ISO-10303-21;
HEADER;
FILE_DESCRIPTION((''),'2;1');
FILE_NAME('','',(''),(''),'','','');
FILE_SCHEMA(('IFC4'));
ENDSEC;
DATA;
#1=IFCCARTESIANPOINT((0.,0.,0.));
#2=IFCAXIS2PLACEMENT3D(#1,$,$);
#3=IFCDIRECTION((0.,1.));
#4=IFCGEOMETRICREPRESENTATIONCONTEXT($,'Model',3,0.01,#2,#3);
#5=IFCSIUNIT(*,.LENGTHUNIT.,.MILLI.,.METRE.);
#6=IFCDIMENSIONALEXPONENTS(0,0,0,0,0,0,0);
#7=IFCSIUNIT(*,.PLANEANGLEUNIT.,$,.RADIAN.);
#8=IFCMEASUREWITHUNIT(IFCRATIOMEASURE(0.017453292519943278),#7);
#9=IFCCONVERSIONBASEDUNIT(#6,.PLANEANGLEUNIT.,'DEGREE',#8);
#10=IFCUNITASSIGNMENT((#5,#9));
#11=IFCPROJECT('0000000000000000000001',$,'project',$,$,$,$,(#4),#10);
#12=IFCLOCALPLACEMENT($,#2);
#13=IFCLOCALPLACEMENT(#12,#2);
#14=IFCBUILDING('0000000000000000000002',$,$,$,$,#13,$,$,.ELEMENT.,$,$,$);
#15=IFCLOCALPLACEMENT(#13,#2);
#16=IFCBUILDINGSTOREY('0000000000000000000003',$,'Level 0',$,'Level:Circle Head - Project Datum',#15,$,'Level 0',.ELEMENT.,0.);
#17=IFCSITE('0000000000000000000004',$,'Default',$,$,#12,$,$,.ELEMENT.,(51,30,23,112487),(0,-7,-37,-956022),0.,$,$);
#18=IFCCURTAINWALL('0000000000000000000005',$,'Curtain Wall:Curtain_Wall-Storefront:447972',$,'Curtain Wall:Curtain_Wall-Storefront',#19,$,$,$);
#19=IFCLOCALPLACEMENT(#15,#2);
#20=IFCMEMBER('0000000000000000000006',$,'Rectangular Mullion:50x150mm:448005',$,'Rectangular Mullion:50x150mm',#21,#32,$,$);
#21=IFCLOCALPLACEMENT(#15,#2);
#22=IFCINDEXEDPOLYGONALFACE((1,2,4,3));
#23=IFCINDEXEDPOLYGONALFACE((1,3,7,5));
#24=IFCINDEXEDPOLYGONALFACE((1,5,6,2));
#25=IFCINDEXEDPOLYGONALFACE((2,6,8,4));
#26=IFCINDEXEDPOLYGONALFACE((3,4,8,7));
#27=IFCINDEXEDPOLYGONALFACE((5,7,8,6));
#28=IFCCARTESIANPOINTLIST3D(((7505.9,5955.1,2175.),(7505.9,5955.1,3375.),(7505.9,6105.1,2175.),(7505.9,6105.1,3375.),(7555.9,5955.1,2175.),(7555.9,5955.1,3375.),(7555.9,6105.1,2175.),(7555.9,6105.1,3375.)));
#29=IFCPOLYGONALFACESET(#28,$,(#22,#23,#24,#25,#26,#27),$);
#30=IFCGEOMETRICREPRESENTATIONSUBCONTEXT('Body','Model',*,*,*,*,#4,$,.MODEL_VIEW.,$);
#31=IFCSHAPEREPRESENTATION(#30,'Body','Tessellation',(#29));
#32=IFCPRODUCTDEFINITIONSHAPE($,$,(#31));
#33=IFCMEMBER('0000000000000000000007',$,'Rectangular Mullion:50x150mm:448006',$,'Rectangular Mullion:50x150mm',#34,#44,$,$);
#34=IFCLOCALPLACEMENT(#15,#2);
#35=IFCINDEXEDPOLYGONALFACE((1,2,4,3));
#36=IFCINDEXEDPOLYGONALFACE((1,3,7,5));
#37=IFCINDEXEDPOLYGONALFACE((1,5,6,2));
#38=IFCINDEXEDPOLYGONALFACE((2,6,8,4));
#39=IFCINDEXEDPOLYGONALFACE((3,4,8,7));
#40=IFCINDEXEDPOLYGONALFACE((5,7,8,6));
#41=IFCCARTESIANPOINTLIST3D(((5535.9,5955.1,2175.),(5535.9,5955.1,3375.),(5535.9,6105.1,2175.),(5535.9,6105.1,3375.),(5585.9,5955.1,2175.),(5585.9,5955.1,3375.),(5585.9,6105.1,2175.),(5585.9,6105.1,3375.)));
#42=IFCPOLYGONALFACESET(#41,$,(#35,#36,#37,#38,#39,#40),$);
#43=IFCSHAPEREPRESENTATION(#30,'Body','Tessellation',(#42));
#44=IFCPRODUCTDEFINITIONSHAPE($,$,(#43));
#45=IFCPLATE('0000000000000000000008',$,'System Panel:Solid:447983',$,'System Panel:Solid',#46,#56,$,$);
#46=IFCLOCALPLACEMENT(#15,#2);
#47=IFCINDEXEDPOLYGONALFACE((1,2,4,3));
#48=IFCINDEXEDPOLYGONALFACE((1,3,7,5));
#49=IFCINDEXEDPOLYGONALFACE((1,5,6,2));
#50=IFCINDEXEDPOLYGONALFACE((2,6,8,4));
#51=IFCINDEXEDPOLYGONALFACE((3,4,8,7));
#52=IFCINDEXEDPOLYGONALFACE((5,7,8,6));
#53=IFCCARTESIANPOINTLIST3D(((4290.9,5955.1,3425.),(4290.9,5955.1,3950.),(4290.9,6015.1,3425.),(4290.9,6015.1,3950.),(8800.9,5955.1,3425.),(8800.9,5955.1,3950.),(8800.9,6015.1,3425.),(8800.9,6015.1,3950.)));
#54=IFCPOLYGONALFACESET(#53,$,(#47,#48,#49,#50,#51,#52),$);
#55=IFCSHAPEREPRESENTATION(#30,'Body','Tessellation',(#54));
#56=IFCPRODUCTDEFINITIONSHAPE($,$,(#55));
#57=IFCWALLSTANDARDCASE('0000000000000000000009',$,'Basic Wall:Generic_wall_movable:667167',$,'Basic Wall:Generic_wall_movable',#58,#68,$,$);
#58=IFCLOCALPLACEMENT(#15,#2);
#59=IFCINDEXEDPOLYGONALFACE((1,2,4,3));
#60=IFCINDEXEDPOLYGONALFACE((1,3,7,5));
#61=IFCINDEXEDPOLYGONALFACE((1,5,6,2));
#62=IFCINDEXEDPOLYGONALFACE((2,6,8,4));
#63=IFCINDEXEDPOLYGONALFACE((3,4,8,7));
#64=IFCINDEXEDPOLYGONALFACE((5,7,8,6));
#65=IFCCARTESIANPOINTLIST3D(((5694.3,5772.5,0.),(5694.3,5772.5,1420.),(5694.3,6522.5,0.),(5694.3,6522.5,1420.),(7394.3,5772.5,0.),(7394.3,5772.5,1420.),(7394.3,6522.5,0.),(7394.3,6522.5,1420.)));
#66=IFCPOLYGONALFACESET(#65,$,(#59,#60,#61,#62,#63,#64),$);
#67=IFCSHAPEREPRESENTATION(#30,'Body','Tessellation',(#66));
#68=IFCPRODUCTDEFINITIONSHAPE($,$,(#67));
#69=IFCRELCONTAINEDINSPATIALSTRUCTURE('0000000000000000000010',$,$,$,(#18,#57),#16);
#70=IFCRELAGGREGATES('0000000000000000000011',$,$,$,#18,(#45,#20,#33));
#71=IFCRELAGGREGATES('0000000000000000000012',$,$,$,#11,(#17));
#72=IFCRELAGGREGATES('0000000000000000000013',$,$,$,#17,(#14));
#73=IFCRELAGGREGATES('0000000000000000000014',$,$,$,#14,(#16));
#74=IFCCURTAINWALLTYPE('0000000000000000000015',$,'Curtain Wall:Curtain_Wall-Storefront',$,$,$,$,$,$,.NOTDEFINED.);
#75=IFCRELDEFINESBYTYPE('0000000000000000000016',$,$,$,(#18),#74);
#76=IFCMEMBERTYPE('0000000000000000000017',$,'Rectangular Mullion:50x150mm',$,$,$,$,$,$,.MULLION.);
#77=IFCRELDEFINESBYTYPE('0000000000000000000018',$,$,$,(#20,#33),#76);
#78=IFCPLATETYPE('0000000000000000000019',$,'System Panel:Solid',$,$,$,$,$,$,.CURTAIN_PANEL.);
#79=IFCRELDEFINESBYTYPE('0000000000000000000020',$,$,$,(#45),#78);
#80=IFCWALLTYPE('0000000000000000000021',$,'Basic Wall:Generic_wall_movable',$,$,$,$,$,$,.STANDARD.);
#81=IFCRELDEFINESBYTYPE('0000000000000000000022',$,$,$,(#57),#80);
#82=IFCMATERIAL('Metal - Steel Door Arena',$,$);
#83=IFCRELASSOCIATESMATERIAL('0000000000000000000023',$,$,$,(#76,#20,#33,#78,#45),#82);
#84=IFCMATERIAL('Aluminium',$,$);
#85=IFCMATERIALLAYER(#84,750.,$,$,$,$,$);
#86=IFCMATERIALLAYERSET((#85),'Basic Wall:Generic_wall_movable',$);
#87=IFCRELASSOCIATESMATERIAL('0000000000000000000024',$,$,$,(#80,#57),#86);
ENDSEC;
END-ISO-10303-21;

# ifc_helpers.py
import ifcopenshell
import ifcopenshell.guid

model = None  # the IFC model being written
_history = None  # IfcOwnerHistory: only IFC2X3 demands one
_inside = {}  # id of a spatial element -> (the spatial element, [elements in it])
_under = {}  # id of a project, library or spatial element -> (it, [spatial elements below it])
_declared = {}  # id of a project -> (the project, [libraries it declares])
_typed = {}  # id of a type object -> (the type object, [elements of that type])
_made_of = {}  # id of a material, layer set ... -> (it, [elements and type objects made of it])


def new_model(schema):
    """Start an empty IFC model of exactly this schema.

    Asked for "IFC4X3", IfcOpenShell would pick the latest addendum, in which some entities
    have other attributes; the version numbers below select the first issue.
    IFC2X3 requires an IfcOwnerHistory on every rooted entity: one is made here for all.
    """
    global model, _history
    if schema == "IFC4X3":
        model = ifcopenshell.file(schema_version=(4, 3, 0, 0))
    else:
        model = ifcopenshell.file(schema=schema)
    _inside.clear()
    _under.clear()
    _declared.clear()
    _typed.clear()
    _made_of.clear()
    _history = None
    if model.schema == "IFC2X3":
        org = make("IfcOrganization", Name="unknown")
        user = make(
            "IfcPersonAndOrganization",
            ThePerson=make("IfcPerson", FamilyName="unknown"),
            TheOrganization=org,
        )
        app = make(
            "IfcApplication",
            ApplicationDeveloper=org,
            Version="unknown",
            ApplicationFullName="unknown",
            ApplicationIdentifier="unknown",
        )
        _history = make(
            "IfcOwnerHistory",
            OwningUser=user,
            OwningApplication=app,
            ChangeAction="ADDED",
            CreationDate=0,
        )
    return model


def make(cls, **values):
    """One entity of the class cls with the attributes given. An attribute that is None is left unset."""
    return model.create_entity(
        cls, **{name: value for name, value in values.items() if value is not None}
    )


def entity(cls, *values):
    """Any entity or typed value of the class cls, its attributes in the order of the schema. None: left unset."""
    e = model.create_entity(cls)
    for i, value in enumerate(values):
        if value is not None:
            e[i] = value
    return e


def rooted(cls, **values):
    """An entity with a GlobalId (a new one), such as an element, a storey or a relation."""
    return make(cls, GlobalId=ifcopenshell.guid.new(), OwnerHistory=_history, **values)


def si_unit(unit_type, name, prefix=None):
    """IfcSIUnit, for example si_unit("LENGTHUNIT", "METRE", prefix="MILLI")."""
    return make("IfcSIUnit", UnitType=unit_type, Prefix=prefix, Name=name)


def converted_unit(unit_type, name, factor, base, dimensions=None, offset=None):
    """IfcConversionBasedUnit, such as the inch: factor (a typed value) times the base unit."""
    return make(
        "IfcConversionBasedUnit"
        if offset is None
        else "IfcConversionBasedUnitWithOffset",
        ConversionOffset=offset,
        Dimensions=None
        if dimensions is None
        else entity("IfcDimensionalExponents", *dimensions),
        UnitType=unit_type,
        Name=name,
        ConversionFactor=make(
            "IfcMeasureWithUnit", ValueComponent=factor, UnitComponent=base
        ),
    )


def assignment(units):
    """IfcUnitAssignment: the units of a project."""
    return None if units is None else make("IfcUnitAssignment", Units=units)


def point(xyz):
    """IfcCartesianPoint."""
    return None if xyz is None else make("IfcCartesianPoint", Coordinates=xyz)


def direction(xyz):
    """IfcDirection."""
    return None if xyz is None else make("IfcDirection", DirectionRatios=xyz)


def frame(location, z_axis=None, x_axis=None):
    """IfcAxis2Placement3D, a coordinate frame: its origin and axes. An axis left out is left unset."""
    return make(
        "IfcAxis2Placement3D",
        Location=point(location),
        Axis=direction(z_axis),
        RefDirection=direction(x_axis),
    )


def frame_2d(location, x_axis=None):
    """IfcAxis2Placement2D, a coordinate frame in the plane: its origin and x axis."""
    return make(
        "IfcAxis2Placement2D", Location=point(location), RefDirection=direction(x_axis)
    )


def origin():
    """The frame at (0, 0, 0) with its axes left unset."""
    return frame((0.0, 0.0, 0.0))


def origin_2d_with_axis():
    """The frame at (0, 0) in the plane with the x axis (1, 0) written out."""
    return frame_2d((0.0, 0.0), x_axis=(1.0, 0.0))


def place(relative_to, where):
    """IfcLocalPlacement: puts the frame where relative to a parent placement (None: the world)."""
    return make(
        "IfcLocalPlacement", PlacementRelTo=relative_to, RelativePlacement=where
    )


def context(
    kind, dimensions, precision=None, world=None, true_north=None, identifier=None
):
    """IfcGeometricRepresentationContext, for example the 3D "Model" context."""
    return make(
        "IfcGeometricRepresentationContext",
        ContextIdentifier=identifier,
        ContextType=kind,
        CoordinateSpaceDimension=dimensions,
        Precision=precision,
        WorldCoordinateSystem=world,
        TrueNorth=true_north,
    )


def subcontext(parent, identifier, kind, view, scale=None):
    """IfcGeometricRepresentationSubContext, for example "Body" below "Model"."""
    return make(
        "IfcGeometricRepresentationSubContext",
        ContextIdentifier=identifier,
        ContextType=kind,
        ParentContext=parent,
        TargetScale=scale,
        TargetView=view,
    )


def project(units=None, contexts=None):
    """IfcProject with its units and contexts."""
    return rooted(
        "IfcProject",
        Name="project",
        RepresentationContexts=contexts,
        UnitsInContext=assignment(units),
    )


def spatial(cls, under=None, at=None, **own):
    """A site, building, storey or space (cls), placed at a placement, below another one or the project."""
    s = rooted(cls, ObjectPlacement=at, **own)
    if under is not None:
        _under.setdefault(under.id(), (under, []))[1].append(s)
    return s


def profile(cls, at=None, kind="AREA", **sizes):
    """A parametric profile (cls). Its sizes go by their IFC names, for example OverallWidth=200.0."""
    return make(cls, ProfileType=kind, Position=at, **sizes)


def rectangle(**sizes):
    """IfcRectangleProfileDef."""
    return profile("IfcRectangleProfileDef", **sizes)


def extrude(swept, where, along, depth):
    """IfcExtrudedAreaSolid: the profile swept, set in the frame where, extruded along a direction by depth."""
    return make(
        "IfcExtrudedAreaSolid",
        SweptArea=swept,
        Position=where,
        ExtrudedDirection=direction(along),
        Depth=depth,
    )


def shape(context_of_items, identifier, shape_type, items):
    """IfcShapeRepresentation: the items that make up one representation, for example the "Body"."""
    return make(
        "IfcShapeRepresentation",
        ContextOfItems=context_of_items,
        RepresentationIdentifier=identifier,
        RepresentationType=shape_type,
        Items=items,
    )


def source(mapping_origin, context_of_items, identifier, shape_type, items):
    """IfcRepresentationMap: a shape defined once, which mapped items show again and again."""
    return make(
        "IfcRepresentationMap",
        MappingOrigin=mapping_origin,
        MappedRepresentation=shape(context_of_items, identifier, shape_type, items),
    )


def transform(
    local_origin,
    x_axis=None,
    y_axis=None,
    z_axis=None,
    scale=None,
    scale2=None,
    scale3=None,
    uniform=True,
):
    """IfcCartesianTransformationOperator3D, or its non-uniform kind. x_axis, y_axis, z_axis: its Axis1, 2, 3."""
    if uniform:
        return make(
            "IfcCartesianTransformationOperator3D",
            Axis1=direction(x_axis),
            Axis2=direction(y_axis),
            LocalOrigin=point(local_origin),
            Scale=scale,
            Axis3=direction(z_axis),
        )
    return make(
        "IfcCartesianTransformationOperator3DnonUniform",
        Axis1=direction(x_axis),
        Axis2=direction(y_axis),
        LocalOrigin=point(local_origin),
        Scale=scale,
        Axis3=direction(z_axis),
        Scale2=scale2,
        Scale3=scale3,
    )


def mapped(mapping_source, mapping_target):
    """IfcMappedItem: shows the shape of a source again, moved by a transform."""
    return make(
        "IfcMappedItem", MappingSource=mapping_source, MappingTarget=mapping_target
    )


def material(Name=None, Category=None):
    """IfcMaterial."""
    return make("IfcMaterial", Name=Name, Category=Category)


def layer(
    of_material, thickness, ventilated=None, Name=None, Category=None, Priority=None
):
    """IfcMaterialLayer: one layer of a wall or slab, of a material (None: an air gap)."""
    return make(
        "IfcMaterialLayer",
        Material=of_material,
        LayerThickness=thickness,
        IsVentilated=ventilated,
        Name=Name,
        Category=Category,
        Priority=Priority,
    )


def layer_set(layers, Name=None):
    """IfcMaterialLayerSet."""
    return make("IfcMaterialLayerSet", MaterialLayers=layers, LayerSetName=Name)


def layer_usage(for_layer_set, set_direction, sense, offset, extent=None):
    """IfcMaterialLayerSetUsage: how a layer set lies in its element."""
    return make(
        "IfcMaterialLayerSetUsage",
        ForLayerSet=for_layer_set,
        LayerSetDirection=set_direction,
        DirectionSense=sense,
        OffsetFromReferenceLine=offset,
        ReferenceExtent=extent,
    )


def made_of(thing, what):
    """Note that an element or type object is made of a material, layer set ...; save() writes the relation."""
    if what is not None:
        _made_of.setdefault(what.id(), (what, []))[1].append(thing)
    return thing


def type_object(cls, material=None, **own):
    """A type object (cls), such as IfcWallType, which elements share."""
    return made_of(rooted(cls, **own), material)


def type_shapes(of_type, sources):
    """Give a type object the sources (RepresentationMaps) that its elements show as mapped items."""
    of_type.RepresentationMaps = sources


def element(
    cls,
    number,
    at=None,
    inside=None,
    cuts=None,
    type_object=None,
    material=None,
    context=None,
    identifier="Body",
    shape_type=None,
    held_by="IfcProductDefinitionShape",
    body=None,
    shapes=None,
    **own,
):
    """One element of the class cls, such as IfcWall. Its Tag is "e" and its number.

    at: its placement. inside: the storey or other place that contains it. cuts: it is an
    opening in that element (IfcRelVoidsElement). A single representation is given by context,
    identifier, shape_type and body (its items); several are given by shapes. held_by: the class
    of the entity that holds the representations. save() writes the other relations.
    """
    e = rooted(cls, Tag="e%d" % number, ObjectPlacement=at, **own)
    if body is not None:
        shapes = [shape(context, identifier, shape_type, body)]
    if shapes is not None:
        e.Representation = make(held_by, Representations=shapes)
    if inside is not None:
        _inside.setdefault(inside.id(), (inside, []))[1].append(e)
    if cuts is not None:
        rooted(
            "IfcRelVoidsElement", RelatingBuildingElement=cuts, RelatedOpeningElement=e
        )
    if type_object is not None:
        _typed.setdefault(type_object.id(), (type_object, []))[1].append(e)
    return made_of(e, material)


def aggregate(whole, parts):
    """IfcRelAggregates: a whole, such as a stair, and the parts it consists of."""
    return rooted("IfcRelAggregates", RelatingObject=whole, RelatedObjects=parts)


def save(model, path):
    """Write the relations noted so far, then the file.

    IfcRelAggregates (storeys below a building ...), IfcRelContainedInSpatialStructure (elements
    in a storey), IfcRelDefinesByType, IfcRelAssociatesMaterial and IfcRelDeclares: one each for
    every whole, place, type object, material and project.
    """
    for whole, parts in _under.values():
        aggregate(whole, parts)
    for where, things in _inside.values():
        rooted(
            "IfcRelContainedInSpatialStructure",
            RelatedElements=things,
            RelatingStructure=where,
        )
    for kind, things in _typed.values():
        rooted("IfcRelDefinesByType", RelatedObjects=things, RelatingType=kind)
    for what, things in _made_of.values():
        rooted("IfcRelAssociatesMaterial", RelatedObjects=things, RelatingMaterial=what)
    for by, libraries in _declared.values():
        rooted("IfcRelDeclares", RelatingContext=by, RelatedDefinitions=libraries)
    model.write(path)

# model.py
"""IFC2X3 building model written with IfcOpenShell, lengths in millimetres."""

from ifc_helpers import new_model, entity, si_unit, converted_unit, direction, frame, frame_2d, origin, origin_2d_with_axis, place, context, subcontext, project, spatial, rectangle, extrude, source, transform, mapped, material, layer, layer_set, layer_usage, type_object, type_shapes, element, aggregate, save


model = new_model("IFC2X3")

# Units and contexts
model_context = context("Model", 3, precision=0.01, world=origin(), true_north=direction((0.0, 1.0)))
body_context = subcontext(model_context, "Body", "Model", "MODEL_VIEW")
ifc_project = project(units=[si_unit("LENGTHUNIT", "METRE", prefix="MILLI"), converted_unit("PLANEANGLEUNIT", "DEGREE", entity("IfcRatioMeasure", 0.017453292519943278), si_unit("PLANEANGLEUNIT", "RADIAN"), dimensions=[0, 0, 0, 0, 0, 0, 0])], contexts=[model_context])

# Site, building, storey
site_placement = place(None, origin())
site = spatial("IfcSite", under=ifc_project, at=site_placement, Name="Default", CompositionType="ELEMENT", RefLatitude=(51, 30, 23, 112487), RefLongitude=(0, -7, -37, -956022), RefElevation=0.0)
building_placement = place(site_placement, origin())
building = spatial("IfcBuilding", under=site, at=building_placement, CompositionType="ELEMENT")
storey_placement = place(building_placement, origin())
storey = spatial("IfcBuildingStorey", under=building, at=storey_placement, Name="Level 0", ObjectType="Level:Circle Head - Project Datum", LongName="Level 0", CompositionType="ELEMENT", Elevation=0.0)

# Curtain wall, members, plate
curtain_wall_type = type_object("IfcCurtainWallType", Name="Curtain Wall:Curtain_Wall-Storefront", PredefinedType="NOTDEFINED")
curtain_wall_placement = place(storey_placement, origin())
curtain_wall = element("IfcCurtainWall", 1, at=curtain_wall_placement, inside=storey, type_object=curtain_wall_type, Name="Curtain Wall:Curtain_Wall-Storefront:447972", ObjectType="Curtain Wall:Curtain_Wall-Storefront")
ifc_material_1 = material(Name="Metal - Steel Door Arena")
member_type_1 = type_object("IfcMemberType", Name="Rectangular Mullion:50x150mm", PredefinedType="MULLION", material=ifc_material_1)
shared_shape_1 = source(origin(), body_context, "Body", "SweptSolid", [
    extrude(rectangle(XDim=150.0, YDim=50.0, at=origin_2d_with_axis()), frame((0.0, 0.0, -1200.0), z_axis=(0.0, 0.0, 1.0), x_axis=(0.0, -1.0, 0.0)), (0.0, 0.0, 1.0), 1200.0),
])
type_shapes(member_type_1, [shared_shape_1])
member_1_placement = place(curtain_wall_placement, frame((7530.9, 6030.1, 2175.0), z_axis=(0.0, 0.0, -1.0), x_axis=(-1.0, 0.0, 0.0)))
member_1 = element("IfcMember", 2, at=member_1_placement, type_object=member_type_1, material=ifc_material_1, Name="Rectangular Mullion:50x150mm:448005", ObjectType="Rectangular Mullion:50x150mm", context=body_context, shape_type="MappedRepresentation", body=[
    mapped(shared_shape_1, transform((0.0, 0.0, 0.0), scale=1.0)),
])
member_2_placement = place(curtain_wall_placement, frame((5560.9, 6030.1, 2175.0), z_axis=(0.0, 0.0, -1.0), x_axis=(-1.0, 0.0, 0.0)))
member_2 = element("IfcMember", 3, at=member_2_placement, type_object=member_type_1, material=ifc_material_1, Name="Rectangular Mullion:50x150mm:448006", ObjectType="Rectangular Mullion:50x150mm", context=body_context, shape_type="MappedRepresentation", body=[
    mapped(shared_shape_1, transform((0.0, 0.0, 0.0), scale=1.0)),
])
plate_type_1 = type_object("IfcPlateType", Name="System Panel:Solid", PredefinedType="CURTAIN_PANEL", material=ifc_material_1)
shared_shape_2 = source(origin(), body_context, "Body", "SweptSolid", [
    extrude(rectangle(XDim=525.0, YDim=4510.0, at=frame_2d((0.0, 0.0), x_axis=(1.0, 0.0))), frame((0.0, 15.0, 262.5), z_axis=(0.0, 1.0, 0.0), x_axis=(0.0, 0.0, 1.0)), (0.0, 0.0, 1.0), 60.0),
])
type_shapes(plate_type_1, [shared_shape_2])
plate_1_placement = place(curtain_wall_placement, frame((6545.9, 6030.1, 3425.0), z_axis=(0.0, 0.0, 1.0), x_axis=(-1.0, 0.0, 0.0)))
plate_1 = element("IfcPlate", 4, at=plate_1_placement, type_object=plate_type_1, material=ifc_material_1, Name="System Panel:Solid:447983", ObjectType="System Panel:Solid", context=body_context, shape_type="MappedRepresentation", body=[
    mapped(shared_shape_2, transform((0.0, 0.0, 0.0), scale=1.0)),
])
aggregate(curtain_wall, [plate_1, member_1, member_2])

# Wall
ifc_material_2 = material(Name="Aluminium")
ifc_layer = layer(ifc_material_2, 750.0)
ifc_layer_set = layer_set([ifc_layer], Name="Basic Wall:Generic_wall_movable")
ifc_layer_usage = layer_usage(ifc_layer_set, "AXIS2", "NEGATIVE", 375.0)
wall_type = type_object("IfcWallType", Name="Basic Wall:Generic_wall_movable", PredefinedType="STANDARD", material=ifc_layer_set)
wall_placement = place(storey_placement, frame((5694.3, 6147.5, 0.0)))
element("IfcWallStandardCase", 5, at=wall_placement, inside=storey, type_object=wall_type, material=ifc_layer_usage, Name="Basic Wall:Generic_wall_movable:667167", ObjectType="Basic Wall:Generic_wall_movable", context=body_context, shape_type="SweptSolid", body=[
    extrude(rectangle(XDim=1700.0, YDim=750.0, at=frame_2d((850.0, 0.0), x_axis=(-1.0, 0.0))), origin(), (0.0, 0.0, 1.0), 1420.0),
])

save(model, "model.ifc")
